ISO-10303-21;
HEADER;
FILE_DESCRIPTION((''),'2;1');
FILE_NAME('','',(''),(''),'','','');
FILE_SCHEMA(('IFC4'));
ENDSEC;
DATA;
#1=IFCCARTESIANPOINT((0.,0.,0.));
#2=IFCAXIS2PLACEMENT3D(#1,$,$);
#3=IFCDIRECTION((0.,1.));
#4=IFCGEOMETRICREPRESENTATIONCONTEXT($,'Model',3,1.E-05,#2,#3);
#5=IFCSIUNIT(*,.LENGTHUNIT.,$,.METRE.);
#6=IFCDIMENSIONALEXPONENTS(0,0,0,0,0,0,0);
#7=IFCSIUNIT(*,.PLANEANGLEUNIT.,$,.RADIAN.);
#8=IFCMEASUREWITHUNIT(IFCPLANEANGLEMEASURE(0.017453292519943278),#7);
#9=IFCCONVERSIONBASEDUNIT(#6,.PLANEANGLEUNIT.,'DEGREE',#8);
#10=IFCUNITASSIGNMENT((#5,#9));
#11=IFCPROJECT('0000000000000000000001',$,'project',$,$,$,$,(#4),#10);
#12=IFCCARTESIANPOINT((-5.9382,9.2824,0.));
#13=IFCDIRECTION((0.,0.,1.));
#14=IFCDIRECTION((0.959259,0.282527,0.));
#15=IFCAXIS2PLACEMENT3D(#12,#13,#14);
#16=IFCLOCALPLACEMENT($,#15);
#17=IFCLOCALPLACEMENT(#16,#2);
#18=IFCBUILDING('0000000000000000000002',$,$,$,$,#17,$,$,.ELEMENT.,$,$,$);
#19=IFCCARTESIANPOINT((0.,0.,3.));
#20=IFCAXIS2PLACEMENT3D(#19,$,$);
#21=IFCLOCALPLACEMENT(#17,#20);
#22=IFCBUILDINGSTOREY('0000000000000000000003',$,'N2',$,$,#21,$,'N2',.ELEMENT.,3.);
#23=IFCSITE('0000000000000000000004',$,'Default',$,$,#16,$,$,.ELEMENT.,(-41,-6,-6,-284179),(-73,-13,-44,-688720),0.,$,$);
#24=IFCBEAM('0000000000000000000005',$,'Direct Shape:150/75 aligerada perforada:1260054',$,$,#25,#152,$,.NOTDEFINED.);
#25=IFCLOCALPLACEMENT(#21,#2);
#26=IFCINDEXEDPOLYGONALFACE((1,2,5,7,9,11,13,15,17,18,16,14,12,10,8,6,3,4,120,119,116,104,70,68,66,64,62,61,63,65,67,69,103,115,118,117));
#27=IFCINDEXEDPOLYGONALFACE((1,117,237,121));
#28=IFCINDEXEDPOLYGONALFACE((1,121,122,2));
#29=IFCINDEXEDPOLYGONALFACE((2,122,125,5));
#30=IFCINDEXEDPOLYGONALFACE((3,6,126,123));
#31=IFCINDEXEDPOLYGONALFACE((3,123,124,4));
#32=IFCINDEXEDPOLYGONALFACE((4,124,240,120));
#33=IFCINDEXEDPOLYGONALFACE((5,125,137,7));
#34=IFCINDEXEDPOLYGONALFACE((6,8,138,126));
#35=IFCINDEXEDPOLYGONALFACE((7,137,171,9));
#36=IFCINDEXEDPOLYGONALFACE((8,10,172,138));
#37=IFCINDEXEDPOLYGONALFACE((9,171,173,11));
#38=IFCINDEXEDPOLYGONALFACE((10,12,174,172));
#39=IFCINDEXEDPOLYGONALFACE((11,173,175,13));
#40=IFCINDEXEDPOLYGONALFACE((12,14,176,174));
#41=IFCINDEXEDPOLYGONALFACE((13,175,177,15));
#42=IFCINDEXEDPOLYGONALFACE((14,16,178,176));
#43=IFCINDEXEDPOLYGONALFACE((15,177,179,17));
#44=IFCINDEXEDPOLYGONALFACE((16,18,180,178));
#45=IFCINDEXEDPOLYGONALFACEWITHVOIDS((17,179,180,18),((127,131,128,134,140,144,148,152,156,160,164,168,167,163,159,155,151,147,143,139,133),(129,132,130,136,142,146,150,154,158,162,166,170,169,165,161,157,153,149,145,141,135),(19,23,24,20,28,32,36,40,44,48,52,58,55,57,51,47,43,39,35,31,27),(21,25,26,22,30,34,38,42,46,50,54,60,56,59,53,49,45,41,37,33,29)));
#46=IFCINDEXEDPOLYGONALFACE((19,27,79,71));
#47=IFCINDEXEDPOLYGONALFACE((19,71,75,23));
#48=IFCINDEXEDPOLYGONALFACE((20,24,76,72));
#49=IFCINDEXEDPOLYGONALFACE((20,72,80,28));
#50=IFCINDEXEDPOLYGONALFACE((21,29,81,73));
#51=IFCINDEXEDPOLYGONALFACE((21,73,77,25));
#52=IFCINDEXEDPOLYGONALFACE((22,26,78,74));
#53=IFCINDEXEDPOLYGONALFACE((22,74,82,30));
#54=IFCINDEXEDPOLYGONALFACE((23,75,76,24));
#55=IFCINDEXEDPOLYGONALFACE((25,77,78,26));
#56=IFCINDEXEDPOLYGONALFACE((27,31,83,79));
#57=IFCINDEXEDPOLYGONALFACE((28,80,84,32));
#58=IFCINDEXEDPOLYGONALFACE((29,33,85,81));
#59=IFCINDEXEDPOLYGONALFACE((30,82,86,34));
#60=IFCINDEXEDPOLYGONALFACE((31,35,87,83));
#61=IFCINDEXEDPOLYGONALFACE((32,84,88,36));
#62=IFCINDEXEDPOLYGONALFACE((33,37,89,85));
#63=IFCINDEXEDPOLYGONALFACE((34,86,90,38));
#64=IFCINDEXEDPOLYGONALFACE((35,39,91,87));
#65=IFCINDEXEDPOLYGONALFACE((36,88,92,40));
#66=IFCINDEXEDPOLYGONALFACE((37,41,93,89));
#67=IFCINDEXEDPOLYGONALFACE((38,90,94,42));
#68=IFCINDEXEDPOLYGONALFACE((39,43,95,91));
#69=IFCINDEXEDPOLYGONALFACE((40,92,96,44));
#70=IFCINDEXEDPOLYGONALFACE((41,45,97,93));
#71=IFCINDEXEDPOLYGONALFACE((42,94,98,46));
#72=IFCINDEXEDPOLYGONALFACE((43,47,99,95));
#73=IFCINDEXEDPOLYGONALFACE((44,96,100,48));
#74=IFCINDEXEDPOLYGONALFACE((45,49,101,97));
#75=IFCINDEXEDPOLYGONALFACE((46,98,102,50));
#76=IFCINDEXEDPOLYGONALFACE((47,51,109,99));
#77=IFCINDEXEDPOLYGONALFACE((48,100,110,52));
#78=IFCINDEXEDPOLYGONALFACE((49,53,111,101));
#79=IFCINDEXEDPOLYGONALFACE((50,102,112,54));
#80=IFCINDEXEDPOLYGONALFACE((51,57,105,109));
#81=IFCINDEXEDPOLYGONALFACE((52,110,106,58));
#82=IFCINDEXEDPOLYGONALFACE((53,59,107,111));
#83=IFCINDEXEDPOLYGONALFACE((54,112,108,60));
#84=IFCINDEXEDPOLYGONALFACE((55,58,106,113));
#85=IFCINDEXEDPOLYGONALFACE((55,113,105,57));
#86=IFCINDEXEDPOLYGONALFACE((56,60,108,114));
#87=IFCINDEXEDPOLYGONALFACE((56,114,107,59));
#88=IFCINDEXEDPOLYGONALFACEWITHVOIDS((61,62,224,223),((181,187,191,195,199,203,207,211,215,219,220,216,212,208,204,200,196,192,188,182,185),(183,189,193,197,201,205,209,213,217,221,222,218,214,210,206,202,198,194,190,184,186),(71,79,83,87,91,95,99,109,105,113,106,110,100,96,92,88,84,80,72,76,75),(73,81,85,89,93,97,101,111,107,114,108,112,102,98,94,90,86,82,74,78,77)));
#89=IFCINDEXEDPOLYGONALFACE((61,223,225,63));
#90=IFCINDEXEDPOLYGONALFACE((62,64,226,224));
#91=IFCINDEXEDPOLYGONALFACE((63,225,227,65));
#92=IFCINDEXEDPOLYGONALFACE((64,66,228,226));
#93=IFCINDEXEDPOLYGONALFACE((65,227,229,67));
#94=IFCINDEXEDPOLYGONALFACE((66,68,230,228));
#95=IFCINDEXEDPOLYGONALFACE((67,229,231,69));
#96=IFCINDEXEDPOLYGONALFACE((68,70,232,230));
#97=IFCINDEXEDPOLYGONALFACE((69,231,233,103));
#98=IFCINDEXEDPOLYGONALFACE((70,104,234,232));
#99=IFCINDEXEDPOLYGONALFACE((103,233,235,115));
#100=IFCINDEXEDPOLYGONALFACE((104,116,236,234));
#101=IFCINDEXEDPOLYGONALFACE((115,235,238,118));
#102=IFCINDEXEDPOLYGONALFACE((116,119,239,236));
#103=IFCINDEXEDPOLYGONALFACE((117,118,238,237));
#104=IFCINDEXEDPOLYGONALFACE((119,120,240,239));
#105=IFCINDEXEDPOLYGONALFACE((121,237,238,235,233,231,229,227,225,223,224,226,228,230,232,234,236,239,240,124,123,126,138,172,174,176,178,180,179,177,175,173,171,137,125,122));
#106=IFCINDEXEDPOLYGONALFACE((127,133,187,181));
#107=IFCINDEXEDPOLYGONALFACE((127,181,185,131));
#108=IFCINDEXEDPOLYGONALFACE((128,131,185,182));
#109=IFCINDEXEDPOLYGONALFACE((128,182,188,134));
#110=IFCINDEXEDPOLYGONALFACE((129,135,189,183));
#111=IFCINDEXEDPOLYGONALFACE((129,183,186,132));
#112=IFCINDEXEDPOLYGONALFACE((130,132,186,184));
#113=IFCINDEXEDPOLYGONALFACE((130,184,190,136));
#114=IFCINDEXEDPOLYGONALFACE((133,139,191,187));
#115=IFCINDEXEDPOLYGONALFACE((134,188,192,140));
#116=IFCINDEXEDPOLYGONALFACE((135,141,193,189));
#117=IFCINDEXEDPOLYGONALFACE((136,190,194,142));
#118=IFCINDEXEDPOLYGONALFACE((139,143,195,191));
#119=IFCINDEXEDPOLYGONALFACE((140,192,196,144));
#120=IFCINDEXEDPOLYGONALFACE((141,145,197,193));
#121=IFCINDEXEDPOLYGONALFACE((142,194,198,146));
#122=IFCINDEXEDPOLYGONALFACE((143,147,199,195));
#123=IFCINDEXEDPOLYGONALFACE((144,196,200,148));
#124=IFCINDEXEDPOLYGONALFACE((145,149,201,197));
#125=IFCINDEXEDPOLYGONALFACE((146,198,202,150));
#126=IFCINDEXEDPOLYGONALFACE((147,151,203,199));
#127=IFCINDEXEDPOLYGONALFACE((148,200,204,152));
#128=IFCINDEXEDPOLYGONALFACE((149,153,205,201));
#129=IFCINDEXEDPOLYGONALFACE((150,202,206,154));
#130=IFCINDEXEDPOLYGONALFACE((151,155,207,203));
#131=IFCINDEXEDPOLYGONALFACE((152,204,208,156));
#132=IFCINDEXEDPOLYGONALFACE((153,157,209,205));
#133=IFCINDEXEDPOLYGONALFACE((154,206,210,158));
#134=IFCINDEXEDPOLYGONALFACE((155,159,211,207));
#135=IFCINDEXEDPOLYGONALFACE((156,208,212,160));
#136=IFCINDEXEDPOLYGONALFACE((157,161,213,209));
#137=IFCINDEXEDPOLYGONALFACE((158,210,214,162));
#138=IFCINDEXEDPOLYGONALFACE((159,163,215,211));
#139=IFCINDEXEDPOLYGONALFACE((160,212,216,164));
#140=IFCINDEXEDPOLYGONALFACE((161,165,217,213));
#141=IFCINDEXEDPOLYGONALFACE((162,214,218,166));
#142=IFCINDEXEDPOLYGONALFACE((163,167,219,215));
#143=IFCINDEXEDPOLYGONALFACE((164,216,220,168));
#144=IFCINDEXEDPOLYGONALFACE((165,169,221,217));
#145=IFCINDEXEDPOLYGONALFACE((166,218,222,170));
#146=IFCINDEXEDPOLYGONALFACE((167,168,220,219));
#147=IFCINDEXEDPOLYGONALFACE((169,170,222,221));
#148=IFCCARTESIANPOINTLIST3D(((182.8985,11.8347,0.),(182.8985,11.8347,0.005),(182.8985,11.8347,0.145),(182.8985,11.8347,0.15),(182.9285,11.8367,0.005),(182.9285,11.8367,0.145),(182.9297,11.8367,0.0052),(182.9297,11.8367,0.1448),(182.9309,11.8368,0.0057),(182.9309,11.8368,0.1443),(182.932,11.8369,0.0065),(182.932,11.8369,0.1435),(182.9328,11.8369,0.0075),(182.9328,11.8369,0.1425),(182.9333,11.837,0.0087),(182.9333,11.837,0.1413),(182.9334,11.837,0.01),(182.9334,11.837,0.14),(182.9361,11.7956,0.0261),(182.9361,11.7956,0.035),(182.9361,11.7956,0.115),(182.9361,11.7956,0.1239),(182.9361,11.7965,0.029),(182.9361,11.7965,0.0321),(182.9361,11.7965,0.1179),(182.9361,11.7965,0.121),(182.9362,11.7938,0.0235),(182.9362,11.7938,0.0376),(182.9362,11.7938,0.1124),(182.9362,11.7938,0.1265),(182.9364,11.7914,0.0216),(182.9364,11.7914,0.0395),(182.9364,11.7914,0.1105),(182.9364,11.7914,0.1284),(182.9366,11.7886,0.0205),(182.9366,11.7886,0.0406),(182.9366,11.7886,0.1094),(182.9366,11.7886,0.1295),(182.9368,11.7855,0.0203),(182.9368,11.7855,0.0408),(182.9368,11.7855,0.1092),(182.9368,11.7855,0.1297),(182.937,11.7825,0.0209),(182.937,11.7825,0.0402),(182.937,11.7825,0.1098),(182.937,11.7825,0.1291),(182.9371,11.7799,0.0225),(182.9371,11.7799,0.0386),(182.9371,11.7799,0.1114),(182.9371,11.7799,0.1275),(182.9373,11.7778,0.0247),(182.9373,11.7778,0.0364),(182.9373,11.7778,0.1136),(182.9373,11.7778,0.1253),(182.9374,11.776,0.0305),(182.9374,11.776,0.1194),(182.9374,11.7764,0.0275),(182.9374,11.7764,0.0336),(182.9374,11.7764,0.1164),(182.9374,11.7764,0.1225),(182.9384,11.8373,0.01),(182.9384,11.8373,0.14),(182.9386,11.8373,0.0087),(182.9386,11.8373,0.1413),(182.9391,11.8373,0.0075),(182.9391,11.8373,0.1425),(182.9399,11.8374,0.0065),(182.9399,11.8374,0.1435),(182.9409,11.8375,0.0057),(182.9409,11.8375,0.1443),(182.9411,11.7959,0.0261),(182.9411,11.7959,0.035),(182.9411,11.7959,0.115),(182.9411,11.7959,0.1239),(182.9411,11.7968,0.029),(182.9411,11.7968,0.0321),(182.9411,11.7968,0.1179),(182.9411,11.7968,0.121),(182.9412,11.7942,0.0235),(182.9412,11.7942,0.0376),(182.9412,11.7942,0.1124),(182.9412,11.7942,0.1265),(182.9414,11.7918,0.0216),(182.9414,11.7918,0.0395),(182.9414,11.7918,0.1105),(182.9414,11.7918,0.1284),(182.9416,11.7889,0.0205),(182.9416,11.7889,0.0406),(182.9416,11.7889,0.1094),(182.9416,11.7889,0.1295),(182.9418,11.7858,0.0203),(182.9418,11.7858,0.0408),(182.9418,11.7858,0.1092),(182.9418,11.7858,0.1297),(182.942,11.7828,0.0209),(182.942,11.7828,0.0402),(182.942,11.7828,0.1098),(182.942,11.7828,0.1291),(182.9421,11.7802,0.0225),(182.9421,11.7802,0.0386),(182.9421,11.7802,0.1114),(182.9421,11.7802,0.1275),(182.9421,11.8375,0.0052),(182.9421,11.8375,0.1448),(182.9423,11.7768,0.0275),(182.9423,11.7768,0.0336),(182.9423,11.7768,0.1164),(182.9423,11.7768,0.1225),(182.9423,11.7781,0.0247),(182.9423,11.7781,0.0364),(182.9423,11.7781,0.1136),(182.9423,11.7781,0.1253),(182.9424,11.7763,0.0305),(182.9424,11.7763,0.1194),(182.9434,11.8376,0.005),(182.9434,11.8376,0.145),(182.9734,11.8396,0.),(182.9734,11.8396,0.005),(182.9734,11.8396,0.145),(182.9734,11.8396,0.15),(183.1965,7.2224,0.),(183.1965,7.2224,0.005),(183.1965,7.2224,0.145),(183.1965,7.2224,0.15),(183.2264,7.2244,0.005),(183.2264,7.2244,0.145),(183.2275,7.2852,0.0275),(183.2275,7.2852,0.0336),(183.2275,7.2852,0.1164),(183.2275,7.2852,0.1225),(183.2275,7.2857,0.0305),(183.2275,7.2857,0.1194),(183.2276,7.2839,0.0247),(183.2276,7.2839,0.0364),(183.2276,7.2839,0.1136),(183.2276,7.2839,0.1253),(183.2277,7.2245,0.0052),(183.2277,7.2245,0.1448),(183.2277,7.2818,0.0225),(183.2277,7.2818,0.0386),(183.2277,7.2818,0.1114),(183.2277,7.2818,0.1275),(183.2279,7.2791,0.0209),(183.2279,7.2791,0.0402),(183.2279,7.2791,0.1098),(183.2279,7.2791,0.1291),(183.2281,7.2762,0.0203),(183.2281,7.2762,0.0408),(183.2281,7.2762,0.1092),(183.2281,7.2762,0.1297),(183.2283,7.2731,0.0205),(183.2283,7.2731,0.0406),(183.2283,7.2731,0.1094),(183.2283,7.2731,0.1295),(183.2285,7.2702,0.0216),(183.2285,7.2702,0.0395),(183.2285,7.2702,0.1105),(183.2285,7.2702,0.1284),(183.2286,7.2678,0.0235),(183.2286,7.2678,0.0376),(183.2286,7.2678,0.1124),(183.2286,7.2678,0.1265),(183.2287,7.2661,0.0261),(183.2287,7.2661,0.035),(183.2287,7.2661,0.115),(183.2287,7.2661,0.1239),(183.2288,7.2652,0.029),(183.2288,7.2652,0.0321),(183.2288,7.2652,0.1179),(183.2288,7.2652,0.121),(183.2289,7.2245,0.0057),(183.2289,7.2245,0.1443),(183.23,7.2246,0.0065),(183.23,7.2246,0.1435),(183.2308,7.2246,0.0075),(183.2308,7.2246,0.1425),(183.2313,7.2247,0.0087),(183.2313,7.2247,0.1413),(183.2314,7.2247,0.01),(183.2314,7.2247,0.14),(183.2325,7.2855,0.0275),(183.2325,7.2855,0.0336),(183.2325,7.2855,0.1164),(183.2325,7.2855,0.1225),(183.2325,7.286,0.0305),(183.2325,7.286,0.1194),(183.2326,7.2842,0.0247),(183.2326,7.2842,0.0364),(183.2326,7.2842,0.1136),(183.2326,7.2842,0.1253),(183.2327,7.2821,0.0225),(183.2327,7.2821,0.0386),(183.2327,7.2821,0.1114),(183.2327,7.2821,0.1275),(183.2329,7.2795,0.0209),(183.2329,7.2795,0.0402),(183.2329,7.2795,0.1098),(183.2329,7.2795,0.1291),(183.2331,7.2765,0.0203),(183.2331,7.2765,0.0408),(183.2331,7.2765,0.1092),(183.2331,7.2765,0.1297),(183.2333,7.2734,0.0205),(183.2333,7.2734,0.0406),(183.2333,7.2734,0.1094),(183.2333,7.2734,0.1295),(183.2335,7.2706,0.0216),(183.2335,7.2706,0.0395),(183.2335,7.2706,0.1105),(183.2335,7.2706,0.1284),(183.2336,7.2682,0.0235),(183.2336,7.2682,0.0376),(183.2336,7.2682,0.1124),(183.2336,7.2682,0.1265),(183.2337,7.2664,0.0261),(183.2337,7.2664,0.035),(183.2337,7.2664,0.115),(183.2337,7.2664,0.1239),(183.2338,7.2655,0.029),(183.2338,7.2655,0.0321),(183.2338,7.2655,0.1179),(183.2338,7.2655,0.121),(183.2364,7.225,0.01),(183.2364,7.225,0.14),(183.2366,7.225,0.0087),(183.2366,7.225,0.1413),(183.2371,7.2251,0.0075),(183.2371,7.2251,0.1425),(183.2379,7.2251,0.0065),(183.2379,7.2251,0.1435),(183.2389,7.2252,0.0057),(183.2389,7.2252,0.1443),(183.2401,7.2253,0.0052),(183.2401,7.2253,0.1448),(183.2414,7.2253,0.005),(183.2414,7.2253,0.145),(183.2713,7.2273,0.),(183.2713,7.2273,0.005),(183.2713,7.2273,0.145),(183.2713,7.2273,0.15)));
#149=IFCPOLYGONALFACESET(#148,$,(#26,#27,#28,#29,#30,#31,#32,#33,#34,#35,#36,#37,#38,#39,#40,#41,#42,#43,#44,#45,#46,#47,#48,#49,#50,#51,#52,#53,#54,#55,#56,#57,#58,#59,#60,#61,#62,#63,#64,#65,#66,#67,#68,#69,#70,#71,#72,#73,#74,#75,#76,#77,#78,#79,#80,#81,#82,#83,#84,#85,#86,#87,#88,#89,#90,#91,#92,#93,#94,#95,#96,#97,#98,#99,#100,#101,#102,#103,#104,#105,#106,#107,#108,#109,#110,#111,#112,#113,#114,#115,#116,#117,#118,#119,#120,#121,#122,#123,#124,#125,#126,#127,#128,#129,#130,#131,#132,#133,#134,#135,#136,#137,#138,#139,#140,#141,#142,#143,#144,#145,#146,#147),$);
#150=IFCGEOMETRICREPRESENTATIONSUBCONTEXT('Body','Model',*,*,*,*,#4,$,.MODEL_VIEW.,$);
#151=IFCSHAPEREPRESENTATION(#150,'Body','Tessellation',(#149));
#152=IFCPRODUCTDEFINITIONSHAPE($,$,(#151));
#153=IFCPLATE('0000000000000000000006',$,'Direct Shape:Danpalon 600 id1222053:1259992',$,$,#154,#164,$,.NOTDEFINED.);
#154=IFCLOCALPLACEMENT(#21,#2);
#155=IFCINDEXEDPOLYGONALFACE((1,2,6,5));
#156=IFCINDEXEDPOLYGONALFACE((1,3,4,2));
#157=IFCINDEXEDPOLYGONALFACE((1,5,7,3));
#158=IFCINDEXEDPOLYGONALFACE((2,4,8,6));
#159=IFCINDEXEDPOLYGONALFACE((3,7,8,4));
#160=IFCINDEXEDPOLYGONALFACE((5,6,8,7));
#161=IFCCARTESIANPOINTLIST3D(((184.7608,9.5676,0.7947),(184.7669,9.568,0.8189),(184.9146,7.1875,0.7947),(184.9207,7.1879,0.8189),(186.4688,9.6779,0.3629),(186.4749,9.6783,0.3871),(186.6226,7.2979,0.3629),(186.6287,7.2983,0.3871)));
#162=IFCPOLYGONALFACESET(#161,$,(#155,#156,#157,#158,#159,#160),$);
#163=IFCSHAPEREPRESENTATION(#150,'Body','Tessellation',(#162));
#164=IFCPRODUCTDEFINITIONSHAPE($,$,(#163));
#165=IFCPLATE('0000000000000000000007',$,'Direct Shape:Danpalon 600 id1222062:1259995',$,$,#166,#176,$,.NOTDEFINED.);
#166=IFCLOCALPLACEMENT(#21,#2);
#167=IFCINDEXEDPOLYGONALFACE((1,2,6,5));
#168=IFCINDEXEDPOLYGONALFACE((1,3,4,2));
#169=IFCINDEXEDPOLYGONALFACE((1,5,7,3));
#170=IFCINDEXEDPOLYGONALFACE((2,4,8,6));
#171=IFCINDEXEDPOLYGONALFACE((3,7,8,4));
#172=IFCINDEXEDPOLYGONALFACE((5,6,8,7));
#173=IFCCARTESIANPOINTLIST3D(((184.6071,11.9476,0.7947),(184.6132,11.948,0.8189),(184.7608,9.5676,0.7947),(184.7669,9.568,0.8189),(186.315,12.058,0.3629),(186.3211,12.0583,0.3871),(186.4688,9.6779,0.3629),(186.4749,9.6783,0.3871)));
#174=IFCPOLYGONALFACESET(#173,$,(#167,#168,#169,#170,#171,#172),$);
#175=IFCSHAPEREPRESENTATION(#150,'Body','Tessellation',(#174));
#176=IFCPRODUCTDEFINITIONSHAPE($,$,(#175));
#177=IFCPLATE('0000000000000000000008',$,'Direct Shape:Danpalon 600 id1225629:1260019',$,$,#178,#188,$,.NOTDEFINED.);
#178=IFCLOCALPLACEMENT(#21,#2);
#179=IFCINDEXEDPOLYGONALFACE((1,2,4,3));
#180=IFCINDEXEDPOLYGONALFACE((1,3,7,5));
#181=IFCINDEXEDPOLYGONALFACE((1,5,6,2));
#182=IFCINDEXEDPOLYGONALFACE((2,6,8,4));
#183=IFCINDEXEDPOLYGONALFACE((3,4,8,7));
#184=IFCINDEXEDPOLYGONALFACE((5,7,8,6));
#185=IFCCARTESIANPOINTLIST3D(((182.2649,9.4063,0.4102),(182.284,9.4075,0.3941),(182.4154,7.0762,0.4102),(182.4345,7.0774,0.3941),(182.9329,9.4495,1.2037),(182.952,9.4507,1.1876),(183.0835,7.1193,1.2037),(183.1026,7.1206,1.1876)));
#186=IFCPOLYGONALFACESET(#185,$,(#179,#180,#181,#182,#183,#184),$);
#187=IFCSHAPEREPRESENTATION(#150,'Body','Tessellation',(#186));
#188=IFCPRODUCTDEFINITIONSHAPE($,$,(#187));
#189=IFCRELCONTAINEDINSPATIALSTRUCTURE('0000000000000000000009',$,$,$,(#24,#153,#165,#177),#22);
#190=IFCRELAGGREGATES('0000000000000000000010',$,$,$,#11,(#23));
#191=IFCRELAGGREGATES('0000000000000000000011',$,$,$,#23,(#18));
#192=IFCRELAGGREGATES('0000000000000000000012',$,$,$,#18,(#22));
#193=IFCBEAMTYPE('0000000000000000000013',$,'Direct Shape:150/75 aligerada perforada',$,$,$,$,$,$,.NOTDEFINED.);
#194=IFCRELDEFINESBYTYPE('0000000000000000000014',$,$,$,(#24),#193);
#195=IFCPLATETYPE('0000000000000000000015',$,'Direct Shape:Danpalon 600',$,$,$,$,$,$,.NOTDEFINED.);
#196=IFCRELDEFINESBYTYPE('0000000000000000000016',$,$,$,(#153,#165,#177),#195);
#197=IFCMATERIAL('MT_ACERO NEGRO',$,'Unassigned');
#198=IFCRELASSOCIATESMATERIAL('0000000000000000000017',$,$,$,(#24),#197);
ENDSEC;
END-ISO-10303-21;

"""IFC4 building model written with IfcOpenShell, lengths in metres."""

from ifc_helpers import new_model, entity, si_unit, converted_unit, direction, frame, frame_2d, origin, origin_2d_with_axis, place, context, subcontext, project, spatial, rectangle, circle, i_section, extrude, material, type_object, element, save


model = new_model("IFC4")

# Units and contexts
model_context = context("Model", 3, precision=1e-05, world=origin(), true_north=direction((0.0, 1.0)))
body_context = subcontext(model_context, "Body", "Model", "MODEL_VIEW")
ifc_project = project(units=[si_unit("LENGTHUNIT", "METRE"), converted_unit("PLANEANGLEUNIT", "DEGREE", entity("IfcPlaneAngleMeasure", 0.017453292519943278), si_unit("PLANEANGLEUNIT", "RADIAN"), dimensions=[0, 0, 0, 0, 0, 0, 0])], contexts=[model_context])

# Site, building, storey
site_placement = place(None, frame((-5.9382, 9.2824, 0.0), z_axis=(0.0, 0.0, 1.0), x_axis=(0.959259, 0.282527, 0.0)))
site = spatial("IfcSite", under=ifc_project, at=site_placement, Name="Default", CompositionType="ELEMENT", RefLatitude=(-41, -6, -6, -284179), RefLongitude=(-73, -13, -44, -688720), RefElevation=0.0)
building_placement = place(site_placement, origin())
building = spatial("IfcBuilding", under=site, at=building_placement, CompositionType="ELEMENT")
storey_placement = place(building_placement, frame((0.0, 0.0, 3.0)))
storey = spatial("IfcBuildingStorey", under=building, at=storey_placement, Name="N2", LongName="N2", CompositionType="ELEMENT", Elevation=3.0)

# Beam, openings
ifc_material = material(Name="MT_ACERO NEGRO", Category="Unassigned")
beam_type = type_object("IfcBeamType", Name="Direct Shape:150/75 aligerada perforada", PredefinedType="NOTDEFINED")
beam_placement = place(storey_placement, origin())
beam = element("IfcBeam", 1, at=beam_placement, inside=storey, type_object=beam_type, material=ifc_material, Name="Direct Shape:150/75 aligerada perforada:1260054", PredefinedType="NOTDEFINED", context=body_context, shape_type="SweptSolid", body=[
    extrude(i_section(OverallWidth=0.075, OverallDepth=0.15, WebThickness=0.005, FlangeThickness=0.005, FilletRadius=0.005, at=frame_2d((0.0, 0.0), x_axis=(0.0, 1.0))), frame((183.2339, 7.2249, 0.075), z_axis=(-0.064471, 0.99792, 0.0), x_axis=(0.0, 0.0, 1.0)), (0.0, 0.0, 1.0), 4.6219),
])
opening_1_placement = place(storey_placement, origin())
element("IfcOpeningElement", 2, at=opening_1_placement, cuts=beam, PredefinedType="OPENING", context=body_context, shape_type="SweptSolid", body=[
    extrude(circle(Radius=0.0103, at=origin_2d_with_axis()), frame((182.9367, 11.7863, 0.0305), z_axis=(0.99792, 0.064471, 0.0), x_axis=(0.064471, -0.99792, 0.0)), (0.0, 0.0, 1.0), 0.005),
])
opening_2_placement = place(storey_placement, origin())
element("IfcOpeningElement", 3, at=opening_2_placement, cuts=beam, PredefinedType="OPENING", context=body_context, shape_type="SweptSolid", body=[
    extrude(circle(Radius=0.0103, at=origin_2d_with_axis()), frame((182.9367, 11.7863, 0.1194), z_axis=(0.99792, 0.064471, 0.0), x_axis=(0.064471, -0.99792, 0.0)), (0.0, 0.0, 1.0), 0.005),
])
opening_3_placement = place(storey_placement, origin())
element("IfcOpeningElement", 4, at=opening_3_placement, cuts=beam, PredefinedType="OPENING", context=body_context, shape_type="SweptSolid", body=[
    extrude(circle(Radius=0.0103, at=frame_2d((0.0, 0.0), x_axis=(1.0, 0.0))), frame((183.2281, 7.2754, 0.1194), z_axis=(0.99792, 0.064471, 0.0), x_axis=(-0.064471, 0.99792, 0.0)), (0.0, 0.0, 1.0), 0.005),
])
opening_4_placement = place(storey_placement, origin())
element("IfcOpeningElement", 5, at=opening_4_placement, cuts=beam, PredefinedType="OPENING", context=body_context, shape_type="SweptSolid", body=[
    extrude(circle(Radius=0.0103, at=frame_2d((0.0, 0.0), x_axis=(1.0, 0.0))), frame((183.2281, 7.2754, 0.0305), z_axis=(0.99792, 0.064471, 0.0), x_axis=(-0.064471, 0.99792, 0.0)), (0.0, 0.0, 1.0), 0.005),
])

# Plates
plate_type = type_object("IfcPlateType", Name="Direct Shape:Danpalon 600", PredefinedType="NOTDEFINED")
plate_1_placement = place(storey_placement, origin())
element("IfcPlate", 6, at=plate_1_placement, inside=storey, type_object=plate_type, Name="Direct Shape:Danpalon 600 id1222053:1259992", PredefinedType="NOTDEFINED", context=body_context, shape_type="SweptSolid", body=[
    extrude(rectangle(XDim=0.025, YDim=1.7652, at=origin_2d_with_axis()), frame((185.7716, 7.2429, 0.5909), z_axis=(-0.064471, 0.99792, 0.0), x_axis=(0.24414, 0.015773, 0.969612)), (0.0, 0.0, 1.0), 2.385),
])
plate_2_placement = place(storey_placement, origin())
element("IfcPlate", 7, at=plate_2_placement, inside=storey, type_object=plate_type, Name="Direct Shape:Danpalon 600 id1222062:1259995", PredefinedType="NOTDEFINED", context=body_context, shape_type="SweptSolid", body=[
    extrude(rectangle(XDim=0.025, YDim=1.7652, at=frame_2d((0.0, 0.0), x_axis=(1.0, 0.0))), frame((185.6179, 9.6229, 0.5909), z_axis=(-0.064471, 0.99792, 0.0), x_axis=(0.24414, 0.015773, 0.969612)), (0.0, 0.0, 1.0), 2.385),
])
plate_3_placement = place(storey_placement, origin())
element("IfcPlate", 8, at=plate_3_placement, inside=storey, type_object=plate_type, Name="Direct Shape:Danpalon 600 id1225629:1260019", PredefinedType="NOTDEFINED", context=body_context, shape_type="SweptSolid", body=[
    extrude(rectangle(XDim=1.0381, YDim=0.025, at=frame_2d((0.0, 0.0), x_axis=(0.0, 1.0))), frame((182.759, 7.0984, 0.7989), z_axis=(-0.064471, 0.99792, 0.0), x_axis=(-0.762714, -0.049276, 0.644857)), (0.0, 0.0, 1.0), 2.335),
])

save(model, "model.ifc")
